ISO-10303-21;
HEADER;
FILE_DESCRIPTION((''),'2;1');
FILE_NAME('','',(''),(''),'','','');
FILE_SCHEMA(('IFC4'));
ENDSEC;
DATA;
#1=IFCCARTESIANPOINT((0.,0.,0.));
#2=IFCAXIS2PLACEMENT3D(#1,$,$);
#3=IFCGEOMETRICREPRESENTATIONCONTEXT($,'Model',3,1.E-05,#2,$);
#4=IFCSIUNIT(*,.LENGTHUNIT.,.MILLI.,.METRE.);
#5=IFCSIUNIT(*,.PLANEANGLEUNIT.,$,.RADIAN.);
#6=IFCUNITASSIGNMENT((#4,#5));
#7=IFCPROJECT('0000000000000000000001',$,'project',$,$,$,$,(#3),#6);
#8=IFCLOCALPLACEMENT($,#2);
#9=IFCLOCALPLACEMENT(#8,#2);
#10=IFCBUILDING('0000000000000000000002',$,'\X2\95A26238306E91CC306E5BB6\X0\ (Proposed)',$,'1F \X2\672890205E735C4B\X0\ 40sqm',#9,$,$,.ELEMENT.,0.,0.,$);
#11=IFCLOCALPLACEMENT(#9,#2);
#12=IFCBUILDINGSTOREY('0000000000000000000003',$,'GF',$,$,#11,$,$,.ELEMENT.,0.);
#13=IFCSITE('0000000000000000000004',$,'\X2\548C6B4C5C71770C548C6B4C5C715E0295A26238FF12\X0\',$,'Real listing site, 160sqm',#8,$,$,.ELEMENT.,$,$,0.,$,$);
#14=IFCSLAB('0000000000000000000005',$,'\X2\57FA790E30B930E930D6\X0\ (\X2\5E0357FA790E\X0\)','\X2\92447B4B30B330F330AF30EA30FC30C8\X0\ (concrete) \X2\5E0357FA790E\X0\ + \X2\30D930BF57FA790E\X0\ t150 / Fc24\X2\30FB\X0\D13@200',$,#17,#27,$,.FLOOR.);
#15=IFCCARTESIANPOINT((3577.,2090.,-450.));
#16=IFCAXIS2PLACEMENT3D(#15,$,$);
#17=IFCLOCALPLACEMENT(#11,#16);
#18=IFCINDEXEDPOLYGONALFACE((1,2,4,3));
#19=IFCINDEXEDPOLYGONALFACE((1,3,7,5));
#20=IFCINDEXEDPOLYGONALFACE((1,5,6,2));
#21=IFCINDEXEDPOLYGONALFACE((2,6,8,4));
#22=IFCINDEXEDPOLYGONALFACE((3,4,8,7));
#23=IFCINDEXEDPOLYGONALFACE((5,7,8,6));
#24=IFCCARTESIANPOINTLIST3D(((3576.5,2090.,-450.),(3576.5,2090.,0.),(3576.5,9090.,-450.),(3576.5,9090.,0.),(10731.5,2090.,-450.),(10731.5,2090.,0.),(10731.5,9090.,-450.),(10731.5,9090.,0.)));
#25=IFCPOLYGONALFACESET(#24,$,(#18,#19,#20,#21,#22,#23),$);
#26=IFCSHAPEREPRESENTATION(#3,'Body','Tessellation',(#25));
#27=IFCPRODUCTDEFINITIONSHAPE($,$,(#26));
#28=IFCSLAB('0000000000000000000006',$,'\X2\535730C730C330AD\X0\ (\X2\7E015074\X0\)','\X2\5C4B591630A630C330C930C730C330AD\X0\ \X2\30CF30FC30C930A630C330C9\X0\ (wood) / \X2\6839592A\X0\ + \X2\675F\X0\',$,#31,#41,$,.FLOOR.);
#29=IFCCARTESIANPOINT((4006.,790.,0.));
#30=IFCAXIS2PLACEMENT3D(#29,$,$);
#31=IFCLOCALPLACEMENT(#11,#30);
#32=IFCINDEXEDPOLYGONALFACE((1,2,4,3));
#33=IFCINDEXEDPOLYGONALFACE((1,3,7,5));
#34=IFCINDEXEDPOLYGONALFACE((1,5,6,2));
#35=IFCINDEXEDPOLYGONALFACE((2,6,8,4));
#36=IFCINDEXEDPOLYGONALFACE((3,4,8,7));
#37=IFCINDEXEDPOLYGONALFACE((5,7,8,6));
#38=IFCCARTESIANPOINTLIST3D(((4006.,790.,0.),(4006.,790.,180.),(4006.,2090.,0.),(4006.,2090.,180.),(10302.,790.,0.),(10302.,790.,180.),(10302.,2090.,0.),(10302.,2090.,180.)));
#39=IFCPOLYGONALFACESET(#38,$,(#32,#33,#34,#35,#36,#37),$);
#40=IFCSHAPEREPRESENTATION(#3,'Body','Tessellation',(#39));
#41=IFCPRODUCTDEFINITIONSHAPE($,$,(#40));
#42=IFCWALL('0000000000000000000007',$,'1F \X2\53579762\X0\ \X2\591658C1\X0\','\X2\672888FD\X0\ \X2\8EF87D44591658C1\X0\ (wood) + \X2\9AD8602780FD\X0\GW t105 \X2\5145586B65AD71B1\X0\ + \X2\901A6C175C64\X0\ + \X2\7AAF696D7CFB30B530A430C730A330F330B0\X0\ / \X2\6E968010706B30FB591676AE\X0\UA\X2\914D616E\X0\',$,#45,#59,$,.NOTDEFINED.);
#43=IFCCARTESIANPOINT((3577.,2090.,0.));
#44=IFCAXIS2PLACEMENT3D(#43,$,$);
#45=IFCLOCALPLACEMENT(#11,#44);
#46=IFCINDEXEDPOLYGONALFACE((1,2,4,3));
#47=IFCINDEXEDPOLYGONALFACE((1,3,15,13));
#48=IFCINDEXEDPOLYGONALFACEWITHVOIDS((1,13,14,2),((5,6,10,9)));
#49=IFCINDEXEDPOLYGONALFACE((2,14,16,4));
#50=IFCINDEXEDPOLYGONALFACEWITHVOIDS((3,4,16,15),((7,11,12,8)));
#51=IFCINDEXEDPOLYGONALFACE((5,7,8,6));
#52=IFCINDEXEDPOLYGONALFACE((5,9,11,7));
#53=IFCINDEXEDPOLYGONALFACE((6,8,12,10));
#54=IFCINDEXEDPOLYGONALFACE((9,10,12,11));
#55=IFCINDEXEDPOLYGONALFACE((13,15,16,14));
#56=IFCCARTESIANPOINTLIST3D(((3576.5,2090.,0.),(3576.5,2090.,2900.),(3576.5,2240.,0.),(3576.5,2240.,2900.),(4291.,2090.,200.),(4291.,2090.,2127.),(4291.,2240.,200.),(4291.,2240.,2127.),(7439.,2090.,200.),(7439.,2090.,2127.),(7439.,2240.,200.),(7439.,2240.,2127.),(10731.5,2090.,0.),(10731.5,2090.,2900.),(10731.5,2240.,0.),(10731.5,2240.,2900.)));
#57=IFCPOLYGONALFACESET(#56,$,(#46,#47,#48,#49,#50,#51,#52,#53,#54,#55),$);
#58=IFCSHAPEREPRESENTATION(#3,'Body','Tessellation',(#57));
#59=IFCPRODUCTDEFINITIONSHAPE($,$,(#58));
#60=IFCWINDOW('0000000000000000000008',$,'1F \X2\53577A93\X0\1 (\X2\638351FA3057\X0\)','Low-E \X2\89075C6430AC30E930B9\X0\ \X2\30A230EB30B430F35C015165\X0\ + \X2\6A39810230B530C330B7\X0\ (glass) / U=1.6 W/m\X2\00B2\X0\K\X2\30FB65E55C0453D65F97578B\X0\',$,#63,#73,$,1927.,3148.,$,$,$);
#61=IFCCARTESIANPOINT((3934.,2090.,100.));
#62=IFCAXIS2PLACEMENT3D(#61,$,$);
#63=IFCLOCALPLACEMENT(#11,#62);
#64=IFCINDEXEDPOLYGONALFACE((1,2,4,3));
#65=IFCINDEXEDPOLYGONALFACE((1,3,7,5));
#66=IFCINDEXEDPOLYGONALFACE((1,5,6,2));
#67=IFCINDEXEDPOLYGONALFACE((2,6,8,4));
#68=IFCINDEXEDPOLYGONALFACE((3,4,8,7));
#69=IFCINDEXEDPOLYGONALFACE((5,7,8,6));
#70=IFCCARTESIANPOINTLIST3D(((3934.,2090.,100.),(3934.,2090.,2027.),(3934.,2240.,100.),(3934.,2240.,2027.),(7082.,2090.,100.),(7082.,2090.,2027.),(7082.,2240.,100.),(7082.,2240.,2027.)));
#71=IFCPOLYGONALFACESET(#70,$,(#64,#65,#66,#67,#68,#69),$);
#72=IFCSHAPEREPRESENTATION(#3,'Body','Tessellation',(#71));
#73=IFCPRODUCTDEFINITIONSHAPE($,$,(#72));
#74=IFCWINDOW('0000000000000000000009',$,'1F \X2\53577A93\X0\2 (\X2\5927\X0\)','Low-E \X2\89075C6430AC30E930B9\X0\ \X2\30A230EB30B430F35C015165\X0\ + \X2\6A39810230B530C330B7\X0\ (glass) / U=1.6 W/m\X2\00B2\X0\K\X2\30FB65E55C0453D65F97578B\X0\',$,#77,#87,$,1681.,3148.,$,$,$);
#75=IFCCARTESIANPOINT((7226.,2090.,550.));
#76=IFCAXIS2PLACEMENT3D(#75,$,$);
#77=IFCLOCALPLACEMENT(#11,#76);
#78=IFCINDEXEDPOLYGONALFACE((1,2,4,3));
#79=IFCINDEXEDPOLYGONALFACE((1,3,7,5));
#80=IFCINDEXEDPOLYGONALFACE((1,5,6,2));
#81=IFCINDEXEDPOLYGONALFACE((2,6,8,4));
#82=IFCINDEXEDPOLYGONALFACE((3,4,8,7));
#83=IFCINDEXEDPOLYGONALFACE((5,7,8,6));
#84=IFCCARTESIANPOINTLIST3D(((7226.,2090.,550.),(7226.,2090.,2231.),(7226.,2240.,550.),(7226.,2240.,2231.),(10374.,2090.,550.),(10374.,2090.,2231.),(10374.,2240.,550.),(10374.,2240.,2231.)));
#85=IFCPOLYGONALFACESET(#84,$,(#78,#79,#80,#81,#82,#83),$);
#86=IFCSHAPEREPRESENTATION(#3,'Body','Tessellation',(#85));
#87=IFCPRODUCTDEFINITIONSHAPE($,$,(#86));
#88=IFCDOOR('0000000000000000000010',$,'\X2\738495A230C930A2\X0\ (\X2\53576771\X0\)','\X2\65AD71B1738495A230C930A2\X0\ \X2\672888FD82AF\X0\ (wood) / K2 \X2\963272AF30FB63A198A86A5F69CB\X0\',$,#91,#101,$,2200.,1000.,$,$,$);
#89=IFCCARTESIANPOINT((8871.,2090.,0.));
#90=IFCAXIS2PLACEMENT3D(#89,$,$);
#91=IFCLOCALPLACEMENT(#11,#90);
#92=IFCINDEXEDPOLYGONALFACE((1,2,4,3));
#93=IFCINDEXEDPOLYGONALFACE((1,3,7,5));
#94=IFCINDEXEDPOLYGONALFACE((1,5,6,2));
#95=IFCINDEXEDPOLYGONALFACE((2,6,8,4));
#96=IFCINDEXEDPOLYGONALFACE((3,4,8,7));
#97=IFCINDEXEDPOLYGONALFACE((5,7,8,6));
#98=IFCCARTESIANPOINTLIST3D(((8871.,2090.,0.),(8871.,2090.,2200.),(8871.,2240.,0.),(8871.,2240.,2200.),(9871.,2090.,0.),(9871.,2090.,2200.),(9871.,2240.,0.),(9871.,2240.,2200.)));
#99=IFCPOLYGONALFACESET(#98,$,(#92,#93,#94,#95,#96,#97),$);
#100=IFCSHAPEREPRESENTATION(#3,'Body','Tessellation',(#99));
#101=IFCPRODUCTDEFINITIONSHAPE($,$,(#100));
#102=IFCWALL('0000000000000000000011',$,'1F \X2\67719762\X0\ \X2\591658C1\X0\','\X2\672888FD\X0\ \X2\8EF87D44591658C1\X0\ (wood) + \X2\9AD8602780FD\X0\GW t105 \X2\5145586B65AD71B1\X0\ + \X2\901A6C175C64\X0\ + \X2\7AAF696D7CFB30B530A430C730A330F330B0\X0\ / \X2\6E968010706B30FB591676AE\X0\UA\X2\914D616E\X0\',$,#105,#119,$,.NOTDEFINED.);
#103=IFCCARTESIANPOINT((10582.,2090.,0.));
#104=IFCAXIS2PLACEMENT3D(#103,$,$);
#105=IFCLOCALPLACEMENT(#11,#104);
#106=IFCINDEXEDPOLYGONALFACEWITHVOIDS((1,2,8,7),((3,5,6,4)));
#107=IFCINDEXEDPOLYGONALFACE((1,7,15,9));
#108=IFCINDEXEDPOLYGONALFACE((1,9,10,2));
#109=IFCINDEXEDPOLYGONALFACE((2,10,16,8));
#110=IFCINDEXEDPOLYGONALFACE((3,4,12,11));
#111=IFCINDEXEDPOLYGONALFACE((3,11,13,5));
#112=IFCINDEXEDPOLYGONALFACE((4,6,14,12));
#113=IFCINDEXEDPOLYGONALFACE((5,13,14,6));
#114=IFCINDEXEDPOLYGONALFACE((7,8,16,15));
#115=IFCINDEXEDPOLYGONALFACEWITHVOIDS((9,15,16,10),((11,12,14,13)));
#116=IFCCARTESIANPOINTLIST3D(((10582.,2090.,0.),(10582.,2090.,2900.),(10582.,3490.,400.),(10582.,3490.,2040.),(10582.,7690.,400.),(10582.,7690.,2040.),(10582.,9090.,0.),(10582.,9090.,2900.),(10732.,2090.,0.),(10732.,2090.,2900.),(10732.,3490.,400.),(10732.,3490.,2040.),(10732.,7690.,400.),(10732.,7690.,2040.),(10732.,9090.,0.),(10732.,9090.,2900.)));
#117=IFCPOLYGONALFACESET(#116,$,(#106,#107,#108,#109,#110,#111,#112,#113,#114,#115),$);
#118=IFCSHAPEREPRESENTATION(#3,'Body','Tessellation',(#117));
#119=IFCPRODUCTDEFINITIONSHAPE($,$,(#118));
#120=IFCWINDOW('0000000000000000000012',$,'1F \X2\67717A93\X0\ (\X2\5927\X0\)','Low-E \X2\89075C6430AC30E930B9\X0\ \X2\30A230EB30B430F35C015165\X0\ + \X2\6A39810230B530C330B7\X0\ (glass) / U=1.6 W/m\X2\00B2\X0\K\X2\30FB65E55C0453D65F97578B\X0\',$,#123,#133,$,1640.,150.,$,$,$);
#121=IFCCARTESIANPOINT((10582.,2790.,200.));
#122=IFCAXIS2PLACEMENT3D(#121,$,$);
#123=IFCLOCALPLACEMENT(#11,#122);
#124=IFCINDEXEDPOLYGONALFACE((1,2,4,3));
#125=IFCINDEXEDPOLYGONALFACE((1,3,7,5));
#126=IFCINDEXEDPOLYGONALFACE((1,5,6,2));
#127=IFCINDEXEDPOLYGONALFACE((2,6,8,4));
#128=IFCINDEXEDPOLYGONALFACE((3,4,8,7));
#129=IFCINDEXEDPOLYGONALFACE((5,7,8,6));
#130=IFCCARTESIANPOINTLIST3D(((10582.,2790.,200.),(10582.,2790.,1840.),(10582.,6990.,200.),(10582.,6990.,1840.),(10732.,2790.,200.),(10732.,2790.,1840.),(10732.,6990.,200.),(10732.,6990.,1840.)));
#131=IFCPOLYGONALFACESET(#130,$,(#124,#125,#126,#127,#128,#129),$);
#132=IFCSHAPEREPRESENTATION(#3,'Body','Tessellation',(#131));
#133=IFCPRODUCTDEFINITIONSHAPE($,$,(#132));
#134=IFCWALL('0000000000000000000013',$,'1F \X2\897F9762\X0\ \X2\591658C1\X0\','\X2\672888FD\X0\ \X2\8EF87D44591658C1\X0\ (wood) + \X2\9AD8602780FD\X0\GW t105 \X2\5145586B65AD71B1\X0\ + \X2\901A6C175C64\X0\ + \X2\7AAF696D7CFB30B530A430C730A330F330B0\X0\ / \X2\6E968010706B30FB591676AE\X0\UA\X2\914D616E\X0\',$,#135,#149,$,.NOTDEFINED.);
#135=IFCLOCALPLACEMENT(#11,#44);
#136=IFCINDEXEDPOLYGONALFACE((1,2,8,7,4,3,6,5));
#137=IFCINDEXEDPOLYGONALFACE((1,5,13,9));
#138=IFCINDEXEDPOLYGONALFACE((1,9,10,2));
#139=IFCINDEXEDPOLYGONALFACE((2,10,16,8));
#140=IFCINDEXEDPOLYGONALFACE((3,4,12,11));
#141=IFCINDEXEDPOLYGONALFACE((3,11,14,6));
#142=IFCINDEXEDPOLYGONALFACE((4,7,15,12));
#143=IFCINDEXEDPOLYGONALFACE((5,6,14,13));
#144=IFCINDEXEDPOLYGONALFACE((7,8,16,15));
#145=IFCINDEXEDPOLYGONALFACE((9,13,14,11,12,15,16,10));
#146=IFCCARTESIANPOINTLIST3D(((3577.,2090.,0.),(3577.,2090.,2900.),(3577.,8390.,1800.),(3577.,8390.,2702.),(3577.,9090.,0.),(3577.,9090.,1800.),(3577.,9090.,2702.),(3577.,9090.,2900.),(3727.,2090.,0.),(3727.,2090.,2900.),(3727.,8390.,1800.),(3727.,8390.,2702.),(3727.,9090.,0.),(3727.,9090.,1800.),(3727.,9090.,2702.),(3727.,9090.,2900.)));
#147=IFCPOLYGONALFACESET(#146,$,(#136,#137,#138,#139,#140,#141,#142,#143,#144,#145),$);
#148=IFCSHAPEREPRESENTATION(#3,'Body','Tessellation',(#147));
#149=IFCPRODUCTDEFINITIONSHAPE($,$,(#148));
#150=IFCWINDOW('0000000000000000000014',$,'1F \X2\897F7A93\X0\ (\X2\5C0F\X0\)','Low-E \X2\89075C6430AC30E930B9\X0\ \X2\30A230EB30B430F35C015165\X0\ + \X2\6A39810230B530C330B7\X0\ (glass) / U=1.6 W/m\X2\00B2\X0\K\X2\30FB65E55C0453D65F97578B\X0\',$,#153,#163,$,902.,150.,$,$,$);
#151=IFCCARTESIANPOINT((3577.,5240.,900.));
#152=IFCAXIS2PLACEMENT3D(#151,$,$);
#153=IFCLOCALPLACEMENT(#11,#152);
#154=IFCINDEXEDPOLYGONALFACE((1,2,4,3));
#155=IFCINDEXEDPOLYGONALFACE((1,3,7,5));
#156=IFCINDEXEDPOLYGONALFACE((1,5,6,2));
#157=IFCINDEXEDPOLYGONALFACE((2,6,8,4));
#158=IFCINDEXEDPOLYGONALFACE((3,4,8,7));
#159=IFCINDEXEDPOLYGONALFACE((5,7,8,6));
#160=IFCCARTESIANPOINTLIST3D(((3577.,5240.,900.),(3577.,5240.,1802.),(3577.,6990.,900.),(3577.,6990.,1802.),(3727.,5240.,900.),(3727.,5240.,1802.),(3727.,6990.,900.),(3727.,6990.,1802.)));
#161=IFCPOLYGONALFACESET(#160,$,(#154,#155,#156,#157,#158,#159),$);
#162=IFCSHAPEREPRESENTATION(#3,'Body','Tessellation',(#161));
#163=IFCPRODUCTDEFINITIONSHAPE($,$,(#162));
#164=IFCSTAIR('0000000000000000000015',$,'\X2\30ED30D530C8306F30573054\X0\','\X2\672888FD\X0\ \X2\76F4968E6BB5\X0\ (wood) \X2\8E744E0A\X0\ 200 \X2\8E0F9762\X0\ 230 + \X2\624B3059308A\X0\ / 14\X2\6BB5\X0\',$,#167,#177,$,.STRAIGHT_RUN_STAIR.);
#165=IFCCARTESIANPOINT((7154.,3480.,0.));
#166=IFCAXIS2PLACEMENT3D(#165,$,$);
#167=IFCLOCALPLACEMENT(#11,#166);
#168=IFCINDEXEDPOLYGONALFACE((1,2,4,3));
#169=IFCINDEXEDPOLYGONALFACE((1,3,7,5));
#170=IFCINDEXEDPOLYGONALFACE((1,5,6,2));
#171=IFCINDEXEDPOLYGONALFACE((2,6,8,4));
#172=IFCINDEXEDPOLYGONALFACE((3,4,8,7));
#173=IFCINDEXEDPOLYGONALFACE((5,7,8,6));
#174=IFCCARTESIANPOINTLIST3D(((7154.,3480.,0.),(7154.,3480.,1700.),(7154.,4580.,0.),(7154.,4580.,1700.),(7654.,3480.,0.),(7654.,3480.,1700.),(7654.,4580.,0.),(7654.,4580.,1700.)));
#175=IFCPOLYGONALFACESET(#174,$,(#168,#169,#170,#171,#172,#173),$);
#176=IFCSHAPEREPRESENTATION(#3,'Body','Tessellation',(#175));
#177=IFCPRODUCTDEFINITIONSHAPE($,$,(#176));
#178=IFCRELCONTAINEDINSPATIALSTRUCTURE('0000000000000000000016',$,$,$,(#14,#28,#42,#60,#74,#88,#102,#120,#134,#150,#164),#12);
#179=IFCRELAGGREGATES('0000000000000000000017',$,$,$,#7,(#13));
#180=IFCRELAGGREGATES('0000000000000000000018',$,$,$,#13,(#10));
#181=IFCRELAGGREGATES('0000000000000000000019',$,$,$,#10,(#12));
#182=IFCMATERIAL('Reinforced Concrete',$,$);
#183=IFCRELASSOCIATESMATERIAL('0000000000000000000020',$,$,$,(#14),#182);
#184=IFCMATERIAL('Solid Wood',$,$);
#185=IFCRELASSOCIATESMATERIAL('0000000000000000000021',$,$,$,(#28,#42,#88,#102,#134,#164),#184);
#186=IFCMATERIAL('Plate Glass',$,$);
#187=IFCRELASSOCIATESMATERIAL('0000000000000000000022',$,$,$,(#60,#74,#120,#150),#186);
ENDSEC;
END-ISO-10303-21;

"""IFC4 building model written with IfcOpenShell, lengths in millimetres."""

from ifc_helpers import new_model, si_unit, frame, frame_2d, origin, place, context, project, spatial, rectangle, extrude, material, element, fill, save


model = new_model("IFC4")

# Units and contexts
model_context = context("Model", 3, precision=1e-05, world=origin())
ifc_project = project(units=[si_unit("LENGTHUNIT", "METRE", prefix="MILLI"), si_unit("PLANEANGLEUNIT", "RADIAN")], contexts=[model_context])

# Site, building, storey
site_placement = place(None, origin())
site = spatial("IfcSite", under=ifc_project, at=site_placement, Name="和歌山県和歌山市関戸２", ObjectType="Real listing site, 160sqm", CompositionType="ELEMENT", RefElevation=0.0)
building_placement = place(site_placement, origin())
building = spatial("IfcBuilding", under=site, at=building_placement, Name="関戸の里の家 (Proposed)", ObjectType="1F 木造平屋 40sqm", CompositionType="ELEMENT", ElevationOfRefHeight=0.0, ElevationOfTerrain=0.0)
storey_placement = place(building_placement, origin())
storey = spatial("IfcBuildingStorey", under=building, at=storey_placement, Name="GF", CompositionType="ELEMENT", Elevation=0.0)

# Slabs
ifc_material_1 = material(Name="Reinforced Concrete")
slab_1_placement = place(storey_placement, frame((3577.0, 2090.0, -450.0)))
element("IfcSlab", 1, at=slab_1_placement, inside=storey, material=ifc_material_1, Name="基礎スラブ (布基礎)", Description="鉄筋コンクリート (concrete) 布基礎 + ベタ基礎 t150 / Fc24・D13@200", PredefinedType="FLOOR", context=model_context, shape_type="SweptSolid", body=[
    extrude(rectangle(XDim=7155.0, YDim=7000.0, at=frame_2d((3577.0, 3500.0))), frame((3577.0, 2090.0, -450.0)), (0.0, 0.0, 1.0), 450.0),
])
ifc_material_2 = material(Name="Solid Wood")
slab_2_placement = place(storey_placement, frame((4006.0, 790.0, 0.0)))
element("IfcSlab", 2, at=slab_2_placement, inside=storey, material=ifc_material_2, Name="南デッキ (縁側)", Description="屋外ウッドデッキ ハードウッド (wood) / 根太 + 束", PredefinedType="FLOOR", context=model_context, shape_type="SweptSolid", body=[
    extrude(rectangle(XDim=6296.0, YDim=1300.0, at=frame_2d((3148.0, 650.0))), frame((4006.0, 790.0, 0.0)), (0.0, 0.0, 1.0), 180.0),
])

# Wall, openings, windows, door
wall_1_placement = place(storey_placement, frame((3577.0, 2090.0, 0.0)))
wall_1 = element("IfcWall", 3, at=wall_1_placement, inside=storey, material=ifc_material_2, Name="1F 南面 外壁", Description="木製 軸組外壁 (wood) + 高性能GW t105 充填断熱 + 通気層 + 窯業系サイディング / 準耐火・外皮UA配慮", PredefinedType="NOTDEFINED", context=model_context, shape_type="SweptSolid", body=[
    extrude(rectangle(XDim=7155.0, YDim=150.0, at=frame_2d((3577.0, 75.0))), frame((3577.0, 2090.0, 0.0)), (0.0, 0.0, 1.0), 2900.0),
])
opening_1_placement = place(storey_placement, frame((3934.0, 2090.0, 100.0)))
opening_1 = element("IfcOpeningElement", 4, at=opening_1_placement, cuts=wall_1, PredefinedType="NOTDEFINED", context=model_context, shape_type="SweptSolid", body=[
    extrude(rectangle(XDim=3148.0, YDim=150.0, at=frame_2d((1574.0, 75.0))), frame((3934.0, 2090.0, 100.0)), (0.0, 0.0, 1.0), 1927.0),
])
opening_2_placement = place(storey_placement, frame((7226.0, 2090.0, 550.0)))
opening_2 = element("IfcOpeningElement", 5, at=opening_2_placement, cuts=wall_1, PredefinedType="NOTDEFINED", context=model_context, shape_type="SweptSolid", body=[
    extrude(rectangle(XDim=3148.0, YDim=150.0, at=frame_2d((1574.0, 75.0))), frame((7226.0, 2090.0, 550.0)), (0.0, 0.0, 1.0), 1681.0),
])
opening_3_placement = place(storey_placement, frame((8871.0, 2090.0, 0.0)))
opening_3 = element("IfcOpeningElement", 6, at=opening_3_placement, cuts=wall_1, PredefinedType="NOTDEFINED", context=model_context, shape_type="SweptSolid", body=[
    extrude(rectangle(XDim=1000.0, YDim=150.0, at=frame_2d((500.0, 75.0))), frame((8871.0, 2090.0, 0.0)), (0.0, 0.0, 1.0), 2200.0),
])
ifc_material_3 = material(Name="Plate Glass")
window_1_placement = place(storey_placement, frame((3934.0, 2090.0, 100.0)))
window_1 = element("IfcWindow", 7, at=window_1_placement, inside=storey, material=ifc_material_3, Name="1F 南窓1 (掃出し)", Description="Low-E 複層ガラス アルゴン封入 + 樹脂サッシ (glass) / U=1.6 W/m²K・日射取得型", OverallHeight=1927.0, OverallWidth=3148.0, context=model_context, shape_type="SweptSolid", body=[
    extrude(rectangle(XDim=3148.0, YDim=150.0, at=frame_2d((1574.0, 75.0))), frame((3934.0, 2090.0, 100.0)), (0.0, 0.0, 1.0), 1927.0),
])
fill(opening_1, window_1)
window_2_placement = place(storey_placement, frame((7226.0, 2090.0, 550.0)))
window_2 = element("IfcWindow", 8, at=window_2_placement, inside=storey, material=ifc_material_3, Name="1F 南窓2 (大)", Description="Low-E 複層ガラス アルゴン封入 + 樹脂サッシ (glass) / U=1.6 W/m²K・日射取得型", OverallHeight=1681.0, OverallWidth=3148.0, context=model_context, shape_type="SweptSolid", body=[
    extrude(rectangle(XDim=3148.0, YDim=150.0, at=frame_2d((1574.0, 75.0))), frame((7226.0, 2090.0, 550.0)), (0.0, 0.0, 1.0), 1681.0),
])
fill(opening_2, window_2)
door_placement = place(storey_placement, frame((8871.0, 2090.0, 0.0)))
door = element("IfcDoor", 9, at=door_placement, inside=storey, material=ifc_material_2, Name="玄関ドア (南東)", Description="断熱玄関ドア 木製芯 (wood) / K2 防犯・採風機構", OverallHeight=2200.0, OverallWidth=1000.0, context=model_context, shape_type="SweptSolid", body=[
    extrude(rectangle(XDim=1000.0, YDim=150.0, at=frame_2d((500.0, 75.0))), frame((8871.0, 2090.0, 0.0)), (0.0, 0.0, 1.0), 2200.0),
])
fill(opening_3, door)

# Walls, openings, windows
wall_2_placement = place(storey_placement, frame((10582.0, 2090.0, 0.0)))
wall_2 = element("IfcWall", 10, at=wall_2_placement, inside=storey, material=ifc_material_2, Name="1F 東面 外壁", Description="木製 軸組外壁 (wood) + 高性能GW t105 充填断熱 + 通気層 + 窯業系サイディング / 準耐火・外皮UA配慮", PredefinedType="NOTDEFINED", context=model_context, shape_type="SweptSolid", body=[
    extrude(rectangle(XDim=150.0, YDim=7000.0, at=frame_2d((75.0, 3500.0))), frame((10582.0, 2090.0, 0.0)), (0.0, 0.0, 1.0), 2900.0),
])
opening_4_placement = place(storey_placement, frame((10582.0, 2790.0, 200.0)))
opening_4 = element("IfcOpeningElement", 11, at=opening_4_placement, cuts=wall_2, PredefinedType="NOTDEFINED", context=model_context, shape_type="SweptSolid", body=[
    extrude(rectangle(XDim=150.0, YDim=4200.0, at=frame_2d((75.0, 2100.0))), frame((10582.0, 2790.0, 200.0)), (0.0, 0.0, 1.0), 1640.0),
])
window_3_placement = place(storey_placement, frame((10582.0, 2790.0, 200.0)))
window_3 = element("IfcWindow", 12, at=window_3_placement, inside=storey, material=ifc_material_3, Name="1F 東窓 (大)", Description="Low-E 複層ガラス アルゴン封入 + 樹脂サッシ (glass) / U=1.6 W/m²K・日射取得型", OverallHeight=1640.0, OverallWidth=150.0, context=model_context, shape_type="SweptSolid", body=[
    extrude(rectangle(XDim=150.0, YDim=4200.0, at=frame_2d((75.0, 2100.0))), frame((10582.0, 2790.0, 200.0)), (0.0, 0.0, 1.0), 1640.0),
])
fill(opening_4, window_3)
wall_3_placement = place(storey_placement, frame((3577.0, 2090.0, 0.0)))
wall_3 = element("IfcWall", 13, at=wall_3_placement, inside=storey, material=ifc_material_2, Name="1F 西面 外壁", Description="木製 軸組外壁 (wood) + 高性能GW t105 充填断熱 + 通気層 + 窯業系サイディング / 準耐火・外皮UA配慮", PredefinedType="NOTDEFINED", context=model_context, shape_type="SweptSolid", body=[
    extrude(rectangle(XDim=150.0, YDim=7000.0, at=frame_2d((75.0, 3500.0))), frame((3577.0, 2090.0, 0.0)), (0.0, 0.0, 1.0), 2900.0),
])
opening_5_placement = place(storey_placement, frame((3577.0, 5240.0, 900.0)))
opening_5 = element("IfcOpeningElement", 14, at=opening_5_placement, cuts=wall_3, PredefinedType="NOTDEFINED", context=model_context, shape_type="SweptSolid", body=[
    extrude(rectangle(XDim=150.0, YDim=1750.0, at=frame_2d((75.0, 875.0))), frame((3577.0, 5240.0, 900.0)), (0.0, 0.0, 1.0), 902.0),
])
window_4_placement = place(storey_placement, frame((3577.0, 5240.0, 900.0)))
window_4 = element("IfcWindow", 15, at=window_4_placement, inside=storey, material=ifc_material_3, Name="1F 西窓 (小)", Description="Low-E 複層ガラス アルゴン封入 + 樹脂サッシ (glass) / U=1.6 W/m²K・日射取得型", OverallHeight=902.0, OverallWidth=150.0, context=model_context, shape_type="SweptSolid", body=[
    extrude(rectangle(XDim=150.0, YDim=1750.0, at=frame_2d((75.0, 875.0))), frame((3577.0, 5240.0, 900.0)), (0.0, 0.0, 1.0), 902.0),
])
fill(opening_5, window_4)

# Stair
stair_placement = place(storey_placement, frame((7154.0, 3480.0, 0.0)))
element("IfcStair", 16, at=stair_placement, inside=storey, material=ifc_material_2, Name="ロフトはしご", Description="木製 直階段 (wood) 蹴上 200 踏面 230 + 手すり / 14段", PredefinedType="STRAIGHT_RUN_STAIR", context=model_context, shape_type="SweptSolid", body=[
    extrude(rectangle(XDim=500.0, YDim=1100.0, at=frame_2d((250.0, 550.0))), frame((7154.0, 3480.0, 0.0)), (0.0, 0.0, 1.0), 1700.0),
])

save(model, "model.ifc")
